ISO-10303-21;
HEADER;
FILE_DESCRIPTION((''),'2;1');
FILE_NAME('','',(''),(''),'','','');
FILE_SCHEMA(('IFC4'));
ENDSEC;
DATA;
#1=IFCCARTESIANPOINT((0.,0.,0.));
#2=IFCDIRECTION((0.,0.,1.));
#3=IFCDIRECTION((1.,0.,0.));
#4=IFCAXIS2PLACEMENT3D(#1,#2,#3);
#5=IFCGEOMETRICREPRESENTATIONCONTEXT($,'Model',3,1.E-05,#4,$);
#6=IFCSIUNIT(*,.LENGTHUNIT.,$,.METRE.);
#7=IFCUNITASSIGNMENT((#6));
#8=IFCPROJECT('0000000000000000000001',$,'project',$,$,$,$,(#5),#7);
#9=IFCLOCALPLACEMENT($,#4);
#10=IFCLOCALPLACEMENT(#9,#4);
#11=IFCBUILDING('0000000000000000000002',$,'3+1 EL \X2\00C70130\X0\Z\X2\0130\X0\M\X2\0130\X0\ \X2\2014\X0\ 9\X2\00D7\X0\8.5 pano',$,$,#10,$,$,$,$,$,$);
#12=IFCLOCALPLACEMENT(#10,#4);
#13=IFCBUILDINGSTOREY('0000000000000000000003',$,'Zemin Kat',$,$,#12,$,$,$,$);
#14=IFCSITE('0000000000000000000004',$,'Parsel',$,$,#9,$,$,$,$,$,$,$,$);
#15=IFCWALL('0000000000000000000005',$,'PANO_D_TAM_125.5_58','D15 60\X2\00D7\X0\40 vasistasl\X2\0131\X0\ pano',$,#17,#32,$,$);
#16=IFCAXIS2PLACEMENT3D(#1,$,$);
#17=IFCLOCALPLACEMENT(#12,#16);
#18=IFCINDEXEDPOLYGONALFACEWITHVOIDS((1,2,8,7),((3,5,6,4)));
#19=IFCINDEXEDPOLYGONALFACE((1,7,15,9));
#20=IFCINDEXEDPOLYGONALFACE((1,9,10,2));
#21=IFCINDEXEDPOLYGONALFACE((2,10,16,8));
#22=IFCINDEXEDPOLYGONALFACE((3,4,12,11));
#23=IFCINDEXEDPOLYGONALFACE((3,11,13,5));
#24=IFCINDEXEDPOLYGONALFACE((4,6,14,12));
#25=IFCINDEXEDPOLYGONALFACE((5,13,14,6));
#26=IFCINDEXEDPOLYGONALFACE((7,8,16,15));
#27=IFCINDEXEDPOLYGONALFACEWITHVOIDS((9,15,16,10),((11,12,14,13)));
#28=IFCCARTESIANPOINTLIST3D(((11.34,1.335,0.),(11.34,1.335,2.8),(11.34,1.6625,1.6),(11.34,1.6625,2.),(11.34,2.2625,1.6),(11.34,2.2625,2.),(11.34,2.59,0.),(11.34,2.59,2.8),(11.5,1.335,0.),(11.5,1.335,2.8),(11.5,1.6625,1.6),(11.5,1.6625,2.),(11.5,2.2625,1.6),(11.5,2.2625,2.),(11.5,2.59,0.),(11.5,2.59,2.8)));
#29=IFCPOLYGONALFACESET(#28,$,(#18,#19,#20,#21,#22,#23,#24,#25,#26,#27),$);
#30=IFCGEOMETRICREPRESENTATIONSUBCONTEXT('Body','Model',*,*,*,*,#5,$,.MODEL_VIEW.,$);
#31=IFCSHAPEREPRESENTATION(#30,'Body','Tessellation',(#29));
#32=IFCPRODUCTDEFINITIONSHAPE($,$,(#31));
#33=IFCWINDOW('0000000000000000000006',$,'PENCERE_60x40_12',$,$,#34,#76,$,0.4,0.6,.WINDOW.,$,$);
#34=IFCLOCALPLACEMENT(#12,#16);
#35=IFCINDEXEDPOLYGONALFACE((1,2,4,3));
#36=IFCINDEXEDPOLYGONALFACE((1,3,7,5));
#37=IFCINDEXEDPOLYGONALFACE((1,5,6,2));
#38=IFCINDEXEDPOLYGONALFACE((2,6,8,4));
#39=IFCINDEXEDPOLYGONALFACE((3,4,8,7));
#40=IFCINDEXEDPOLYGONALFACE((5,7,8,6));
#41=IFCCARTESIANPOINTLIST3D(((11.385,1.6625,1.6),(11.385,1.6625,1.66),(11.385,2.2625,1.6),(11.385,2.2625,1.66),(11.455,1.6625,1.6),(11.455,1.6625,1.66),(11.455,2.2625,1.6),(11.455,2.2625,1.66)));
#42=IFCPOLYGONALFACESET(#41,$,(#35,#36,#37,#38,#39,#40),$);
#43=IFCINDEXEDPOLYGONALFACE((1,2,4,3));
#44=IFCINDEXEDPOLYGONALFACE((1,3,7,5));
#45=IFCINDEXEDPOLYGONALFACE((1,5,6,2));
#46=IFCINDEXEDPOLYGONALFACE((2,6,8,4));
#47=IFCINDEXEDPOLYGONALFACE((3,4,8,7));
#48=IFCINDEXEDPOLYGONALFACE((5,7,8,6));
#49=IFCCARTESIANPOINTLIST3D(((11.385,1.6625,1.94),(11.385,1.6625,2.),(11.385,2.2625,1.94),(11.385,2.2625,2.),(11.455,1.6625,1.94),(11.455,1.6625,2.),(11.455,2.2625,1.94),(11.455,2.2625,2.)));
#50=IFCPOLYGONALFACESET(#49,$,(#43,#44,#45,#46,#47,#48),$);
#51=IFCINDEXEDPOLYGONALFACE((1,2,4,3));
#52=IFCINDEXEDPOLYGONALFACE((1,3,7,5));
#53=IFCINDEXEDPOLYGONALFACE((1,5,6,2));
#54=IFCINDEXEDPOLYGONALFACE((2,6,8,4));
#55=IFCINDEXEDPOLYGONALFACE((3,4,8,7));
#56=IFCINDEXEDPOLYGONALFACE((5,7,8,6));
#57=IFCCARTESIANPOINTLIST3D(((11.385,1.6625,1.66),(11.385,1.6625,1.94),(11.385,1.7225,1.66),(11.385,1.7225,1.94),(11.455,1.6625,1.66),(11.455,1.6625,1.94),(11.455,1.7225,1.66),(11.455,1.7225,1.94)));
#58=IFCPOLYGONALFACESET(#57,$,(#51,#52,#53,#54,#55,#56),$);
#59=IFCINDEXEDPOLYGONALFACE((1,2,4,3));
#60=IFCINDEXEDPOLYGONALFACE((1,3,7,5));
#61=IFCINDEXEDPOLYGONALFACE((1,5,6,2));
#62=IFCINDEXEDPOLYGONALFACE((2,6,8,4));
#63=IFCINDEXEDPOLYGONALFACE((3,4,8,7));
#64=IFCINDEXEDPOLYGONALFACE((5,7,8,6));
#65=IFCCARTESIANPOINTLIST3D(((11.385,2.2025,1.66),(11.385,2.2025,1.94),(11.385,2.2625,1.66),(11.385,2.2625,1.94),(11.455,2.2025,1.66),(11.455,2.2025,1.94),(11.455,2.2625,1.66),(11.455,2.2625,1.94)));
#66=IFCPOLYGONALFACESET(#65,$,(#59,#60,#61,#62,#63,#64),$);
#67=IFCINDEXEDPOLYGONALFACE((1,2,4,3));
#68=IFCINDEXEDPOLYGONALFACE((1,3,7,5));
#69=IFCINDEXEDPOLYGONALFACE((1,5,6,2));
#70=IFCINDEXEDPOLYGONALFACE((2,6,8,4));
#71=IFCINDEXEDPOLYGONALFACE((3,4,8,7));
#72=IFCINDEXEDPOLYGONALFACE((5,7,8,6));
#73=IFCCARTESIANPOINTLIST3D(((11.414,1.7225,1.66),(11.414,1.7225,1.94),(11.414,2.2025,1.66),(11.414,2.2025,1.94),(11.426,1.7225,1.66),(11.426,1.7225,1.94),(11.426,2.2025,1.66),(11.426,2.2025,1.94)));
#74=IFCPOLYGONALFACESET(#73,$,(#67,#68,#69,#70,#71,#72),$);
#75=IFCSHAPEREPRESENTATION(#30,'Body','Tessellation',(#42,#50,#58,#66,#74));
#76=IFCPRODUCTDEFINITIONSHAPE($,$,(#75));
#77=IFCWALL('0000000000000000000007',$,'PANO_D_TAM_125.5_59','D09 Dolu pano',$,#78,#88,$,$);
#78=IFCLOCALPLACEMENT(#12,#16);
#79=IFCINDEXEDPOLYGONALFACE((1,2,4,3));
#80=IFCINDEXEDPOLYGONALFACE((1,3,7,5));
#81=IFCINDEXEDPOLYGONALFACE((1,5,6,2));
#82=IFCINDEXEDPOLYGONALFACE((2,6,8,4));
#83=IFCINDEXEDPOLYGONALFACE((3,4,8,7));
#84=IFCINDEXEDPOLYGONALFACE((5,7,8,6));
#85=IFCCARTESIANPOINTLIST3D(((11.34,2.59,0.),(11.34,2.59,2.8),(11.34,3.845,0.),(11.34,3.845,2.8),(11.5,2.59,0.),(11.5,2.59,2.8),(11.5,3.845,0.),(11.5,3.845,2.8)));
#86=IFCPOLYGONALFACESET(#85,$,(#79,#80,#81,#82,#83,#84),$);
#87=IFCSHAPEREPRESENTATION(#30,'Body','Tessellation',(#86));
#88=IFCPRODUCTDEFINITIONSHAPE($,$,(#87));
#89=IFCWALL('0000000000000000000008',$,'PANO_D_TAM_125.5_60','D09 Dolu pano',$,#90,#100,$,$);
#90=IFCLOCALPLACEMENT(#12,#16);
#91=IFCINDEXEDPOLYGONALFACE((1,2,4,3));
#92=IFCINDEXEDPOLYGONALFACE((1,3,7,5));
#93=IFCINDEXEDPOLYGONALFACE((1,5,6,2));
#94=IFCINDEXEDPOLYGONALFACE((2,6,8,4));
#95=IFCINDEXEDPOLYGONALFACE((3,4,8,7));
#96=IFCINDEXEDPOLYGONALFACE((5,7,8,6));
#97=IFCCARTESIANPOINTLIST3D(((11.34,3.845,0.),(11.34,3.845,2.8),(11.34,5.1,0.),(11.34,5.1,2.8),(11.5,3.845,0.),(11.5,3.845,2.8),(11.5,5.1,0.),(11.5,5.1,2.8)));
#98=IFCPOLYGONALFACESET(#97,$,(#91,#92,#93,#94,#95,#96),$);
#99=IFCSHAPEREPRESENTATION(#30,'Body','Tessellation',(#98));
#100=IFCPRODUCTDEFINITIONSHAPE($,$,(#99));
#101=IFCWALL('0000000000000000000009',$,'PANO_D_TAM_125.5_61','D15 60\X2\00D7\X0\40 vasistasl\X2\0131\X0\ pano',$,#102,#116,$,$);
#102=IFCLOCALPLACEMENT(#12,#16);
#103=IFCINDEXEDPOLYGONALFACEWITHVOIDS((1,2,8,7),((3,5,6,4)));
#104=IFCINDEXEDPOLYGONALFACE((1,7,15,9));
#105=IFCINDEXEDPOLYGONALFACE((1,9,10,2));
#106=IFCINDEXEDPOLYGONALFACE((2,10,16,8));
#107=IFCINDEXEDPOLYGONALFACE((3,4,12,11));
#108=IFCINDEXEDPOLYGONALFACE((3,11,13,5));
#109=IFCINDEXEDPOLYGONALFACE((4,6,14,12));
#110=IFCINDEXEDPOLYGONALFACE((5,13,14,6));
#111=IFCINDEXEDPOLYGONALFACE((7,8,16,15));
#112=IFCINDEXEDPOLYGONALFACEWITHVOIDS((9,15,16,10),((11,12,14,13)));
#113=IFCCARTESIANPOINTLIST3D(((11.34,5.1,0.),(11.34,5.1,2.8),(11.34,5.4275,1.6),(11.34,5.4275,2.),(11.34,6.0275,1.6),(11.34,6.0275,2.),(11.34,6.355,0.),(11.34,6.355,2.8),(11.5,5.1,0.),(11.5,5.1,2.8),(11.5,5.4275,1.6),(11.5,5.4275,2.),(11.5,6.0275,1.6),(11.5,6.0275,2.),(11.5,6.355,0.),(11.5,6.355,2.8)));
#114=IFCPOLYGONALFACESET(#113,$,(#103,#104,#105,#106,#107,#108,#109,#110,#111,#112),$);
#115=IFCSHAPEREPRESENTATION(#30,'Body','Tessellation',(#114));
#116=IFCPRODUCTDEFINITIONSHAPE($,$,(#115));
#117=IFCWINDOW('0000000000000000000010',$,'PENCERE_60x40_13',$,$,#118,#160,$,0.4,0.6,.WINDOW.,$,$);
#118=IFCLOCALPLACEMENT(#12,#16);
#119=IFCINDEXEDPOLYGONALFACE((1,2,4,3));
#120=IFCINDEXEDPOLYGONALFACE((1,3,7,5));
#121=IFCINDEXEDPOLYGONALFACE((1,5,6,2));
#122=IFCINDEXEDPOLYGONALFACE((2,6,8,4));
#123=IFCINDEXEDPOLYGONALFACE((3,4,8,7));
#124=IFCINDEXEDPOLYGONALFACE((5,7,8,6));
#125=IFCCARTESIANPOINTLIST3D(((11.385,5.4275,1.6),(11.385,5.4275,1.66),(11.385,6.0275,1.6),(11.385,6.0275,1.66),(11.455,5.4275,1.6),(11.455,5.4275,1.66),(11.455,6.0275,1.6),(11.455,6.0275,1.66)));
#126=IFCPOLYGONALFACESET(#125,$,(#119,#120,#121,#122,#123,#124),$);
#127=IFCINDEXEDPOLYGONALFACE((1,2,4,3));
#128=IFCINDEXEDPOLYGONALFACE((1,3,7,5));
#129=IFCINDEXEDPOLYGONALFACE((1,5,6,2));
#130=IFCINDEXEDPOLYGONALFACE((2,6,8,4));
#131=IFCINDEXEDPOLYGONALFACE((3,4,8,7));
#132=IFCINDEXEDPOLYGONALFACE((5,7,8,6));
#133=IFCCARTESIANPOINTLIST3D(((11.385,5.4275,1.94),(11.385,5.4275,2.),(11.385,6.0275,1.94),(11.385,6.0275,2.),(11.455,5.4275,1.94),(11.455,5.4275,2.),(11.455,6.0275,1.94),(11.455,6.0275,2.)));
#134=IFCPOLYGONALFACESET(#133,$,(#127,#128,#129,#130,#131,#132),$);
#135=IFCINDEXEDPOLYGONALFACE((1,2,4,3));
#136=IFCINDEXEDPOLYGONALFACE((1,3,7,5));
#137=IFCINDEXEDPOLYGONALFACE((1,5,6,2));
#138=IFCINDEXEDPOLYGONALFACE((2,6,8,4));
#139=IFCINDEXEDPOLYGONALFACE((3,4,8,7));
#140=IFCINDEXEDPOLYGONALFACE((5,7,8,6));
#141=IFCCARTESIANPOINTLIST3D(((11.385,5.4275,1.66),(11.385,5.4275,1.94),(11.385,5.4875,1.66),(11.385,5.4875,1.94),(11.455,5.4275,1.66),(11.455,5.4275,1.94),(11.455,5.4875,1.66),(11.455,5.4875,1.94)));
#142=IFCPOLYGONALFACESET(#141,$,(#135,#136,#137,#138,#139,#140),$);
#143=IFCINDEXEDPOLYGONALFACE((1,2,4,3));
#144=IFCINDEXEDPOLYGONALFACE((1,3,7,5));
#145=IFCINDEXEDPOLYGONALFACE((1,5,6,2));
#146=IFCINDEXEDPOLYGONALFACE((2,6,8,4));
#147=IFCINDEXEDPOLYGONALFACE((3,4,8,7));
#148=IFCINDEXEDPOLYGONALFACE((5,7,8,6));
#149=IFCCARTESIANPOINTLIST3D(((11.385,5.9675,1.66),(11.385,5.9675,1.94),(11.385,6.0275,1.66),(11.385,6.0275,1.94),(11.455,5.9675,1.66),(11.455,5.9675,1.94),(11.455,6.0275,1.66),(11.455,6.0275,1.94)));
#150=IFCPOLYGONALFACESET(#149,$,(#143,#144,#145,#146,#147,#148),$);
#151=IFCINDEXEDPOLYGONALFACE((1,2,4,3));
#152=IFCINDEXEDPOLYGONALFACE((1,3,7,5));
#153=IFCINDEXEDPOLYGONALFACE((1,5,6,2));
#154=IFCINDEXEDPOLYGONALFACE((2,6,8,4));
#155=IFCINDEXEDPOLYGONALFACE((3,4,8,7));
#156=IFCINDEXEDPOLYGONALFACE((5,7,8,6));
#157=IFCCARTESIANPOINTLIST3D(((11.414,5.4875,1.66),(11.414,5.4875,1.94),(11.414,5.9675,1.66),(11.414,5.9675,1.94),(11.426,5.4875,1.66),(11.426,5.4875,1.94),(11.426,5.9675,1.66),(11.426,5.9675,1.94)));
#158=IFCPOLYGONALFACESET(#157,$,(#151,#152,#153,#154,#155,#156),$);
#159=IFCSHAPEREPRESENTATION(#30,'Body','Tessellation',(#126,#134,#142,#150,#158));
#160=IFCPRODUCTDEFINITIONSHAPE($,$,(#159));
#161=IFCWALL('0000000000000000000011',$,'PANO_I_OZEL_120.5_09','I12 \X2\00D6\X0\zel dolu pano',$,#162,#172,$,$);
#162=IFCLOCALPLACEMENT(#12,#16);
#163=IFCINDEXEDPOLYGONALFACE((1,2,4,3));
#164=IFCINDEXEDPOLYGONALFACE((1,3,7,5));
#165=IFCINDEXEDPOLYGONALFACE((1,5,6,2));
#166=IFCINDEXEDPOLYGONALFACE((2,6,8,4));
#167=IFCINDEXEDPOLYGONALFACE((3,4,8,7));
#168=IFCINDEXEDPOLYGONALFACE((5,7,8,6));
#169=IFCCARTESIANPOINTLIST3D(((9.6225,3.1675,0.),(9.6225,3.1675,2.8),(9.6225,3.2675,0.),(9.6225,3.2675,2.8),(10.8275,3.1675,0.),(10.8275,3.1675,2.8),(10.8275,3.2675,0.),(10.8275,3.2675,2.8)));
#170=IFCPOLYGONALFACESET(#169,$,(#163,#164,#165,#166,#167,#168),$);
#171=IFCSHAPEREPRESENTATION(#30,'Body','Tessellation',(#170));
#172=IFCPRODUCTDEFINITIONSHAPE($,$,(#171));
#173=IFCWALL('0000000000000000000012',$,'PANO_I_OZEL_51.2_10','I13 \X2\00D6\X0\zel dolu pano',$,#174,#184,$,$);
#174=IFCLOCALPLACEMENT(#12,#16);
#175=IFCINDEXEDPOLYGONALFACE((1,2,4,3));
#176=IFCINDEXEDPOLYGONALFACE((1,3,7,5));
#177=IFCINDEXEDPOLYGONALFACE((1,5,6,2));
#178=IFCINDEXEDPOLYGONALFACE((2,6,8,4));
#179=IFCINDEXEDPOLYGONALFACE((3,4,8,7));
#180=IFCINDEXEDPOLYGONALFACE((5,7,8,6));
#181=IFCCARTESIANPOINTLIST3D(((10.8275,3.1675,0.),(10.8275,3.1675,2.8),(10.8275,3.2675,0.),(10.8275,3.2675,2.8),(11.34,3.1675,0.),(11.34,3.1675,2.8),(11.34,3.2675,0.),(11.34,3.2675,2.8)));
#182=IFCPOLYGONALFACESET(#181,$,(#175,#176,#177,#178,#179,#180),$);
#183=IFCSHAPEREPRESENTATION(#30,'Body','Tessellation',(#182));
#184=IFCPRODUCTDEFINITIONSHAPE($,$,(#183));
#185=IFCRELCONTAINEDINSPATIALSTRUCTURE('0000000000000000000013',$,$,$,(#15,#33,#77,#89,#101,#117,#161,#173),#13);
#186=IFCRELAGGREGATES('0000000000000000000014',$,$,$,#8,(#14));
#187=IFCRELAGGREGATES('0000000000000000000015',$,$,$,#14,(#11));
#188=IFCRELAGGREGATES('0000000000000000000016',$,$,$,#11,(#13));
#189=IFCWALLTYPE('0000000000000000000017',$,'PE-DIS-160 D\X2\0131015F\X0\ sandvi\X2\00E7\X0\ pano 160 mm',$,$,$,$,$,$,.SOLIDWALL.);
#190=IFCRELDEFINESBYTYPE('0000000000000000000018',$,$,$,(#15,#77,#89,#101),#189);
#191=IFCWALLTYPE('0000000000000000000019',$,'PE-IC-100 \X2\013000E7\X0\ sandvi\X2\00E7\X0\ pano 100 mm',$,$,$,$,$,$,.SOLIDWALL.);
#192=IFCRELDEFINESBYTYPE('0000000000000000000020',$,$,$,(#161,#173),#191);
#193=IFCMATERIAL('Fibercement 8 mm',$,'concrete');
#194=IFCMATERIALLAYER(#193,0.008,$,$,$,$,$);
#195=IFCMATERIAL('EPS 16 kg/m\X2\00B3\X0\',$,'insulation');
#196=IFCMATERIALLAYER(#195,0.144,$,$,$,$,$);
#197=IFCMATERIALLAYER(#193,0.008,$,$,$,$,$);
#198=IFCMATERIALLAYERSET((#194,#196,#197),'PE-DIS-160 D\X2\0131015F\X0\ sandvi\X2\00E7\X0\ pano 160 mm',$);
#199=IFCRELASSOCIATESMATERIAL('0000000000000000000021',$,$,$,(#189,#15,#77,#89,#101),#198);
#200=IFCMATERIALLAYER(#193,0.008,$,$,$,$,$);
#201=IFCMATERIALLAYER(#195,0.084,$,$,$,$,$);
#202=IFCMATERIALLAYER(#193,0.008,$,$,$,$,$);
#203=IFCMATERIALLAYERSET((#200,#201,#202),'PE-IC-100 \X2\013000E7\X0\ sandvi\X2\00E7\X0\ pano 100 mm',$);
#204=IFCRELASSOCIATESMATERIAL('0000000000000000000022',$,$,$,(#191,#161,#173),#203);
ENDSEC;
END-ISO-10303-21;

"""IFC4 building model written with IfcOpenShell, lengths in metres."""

from ifc_helpers import new_model, si_unit, frame, origin_with_axes, place, context, subcontext, project, spatial, line, indexed_curve, outline, extrude, material, layer, layer_set, layer_usage, type_object, element, fill, save


model = new_model("IFC4")

# Units and contexts
model_context = context("Model", 3, precision=1e-05, world=origin_with_axes())
body_context = subcontext(model_context, "Body", "Model", "MODEL_VIEW")
ifc_project = project(units=[si_unit("LENGTHUNIT", "METRE")], contexts=[model_context])

# Site, building, storey
site_placement = place(None, origin_with_axes())
site = spatial("IfcSite", under=ifc_project, at=site_placement, Name="Parsel")
building_placement = place(site_placement, origin_with_axes())
building = spatial("IfcBuilding", under=site, at=building_placement, Name="3+1 EL ÇİZİMİ — 9×8.5 pano")
storey_placement = place(building_placement, origin_with_axes())
storey = spatial("IfcBuildingStorey", under=building, at=storey_placement, Name="Zemin Kat")

# Shared definitions
ifc_material_1 = material(Name="Fibercement 8 mm", Category="concrete")
ifc_layer_1 = layer(ifc_material_1, 0.008)
ifc_material_2 = material(Name="EPS 16 kg/m³", Category="insulation")
ifc_layer_2 = layer(ifc_material_2, 0.144)
ifc_layer_3 = layer(ifc_material_1, 0.008)
ifc_layer_set_1 = layer_set([ifc_layer_1, ifc_layer_2, ifc_layer_3], Name="PE-DIS-160 Dış sandviç pano 160 mm")
wall_type_1 = type_object("IfcWallType", Name="PE-DIS-160 Dış sandviç pano 160 mm", PredefinedType="SOLIDWALL", material=ifc_layer_set_1)

# Wall, opening, window
ifc_layer_usage_1 = layer_usage(ifc_layer_set_1, "AXIS2", "POSITIVE", 0.0)
wall_1_placement = place(storey_placement, frame((11.5, 1.335, 0.0), z_axis=(0.0, 0.0, 1.0), x_axis=(0.0, 1.0, 0.0)))
wall_1 = element("IfcWall", 1, at=wall_1_placement, inside=storey, type_object=wall_type_1, material=ifc_layer_usage_1, Name="PANO_D_TAM_125.5_58", Description="D15 60×40 vasistaslı pano", context=body_context, shape_type="SweptSolid", body=[
    extrude(outline(indexed_curve([(0.0, 0.0), (1.255, 0.0), (1.255, 0.16), (0.0, 0.16)], segments=[line(1, 2, 3, 4, 1)])), origin_with_axes(), (0.0, 0.0, 1.0), 2.8),
])
opening_1_placement = place(wall_1_placement, origin_with_axes())
opening_1 = element("IfcOpeningElement", 2, at=opening_1_placement, cuts=wall_1, PredefinedType="OPENING", context=body_context, shape_type="SweptSolid", body=[
    extrude(outline(indexed_curve([(0.0, 0.0), (0.6, 0.0), (0.6, 0.2), (0.0, 0.2)], segments=[line(1, 2, 3, 4, 1)])), frame((0.3275, -0.02, 1.6), z_axis=(0.0, 0.0, 1.0), x_axis=(1.0, 0.0, 0.0)), (0.0, 0.0, 1.0), 0.4),
])
window_1_placement = place(storey_placement, frame((11.5, 1.335, 0.0), z_axis=(0.0, 0.0, 1.0), x_axis=(0.0, 1.0, 0.0)))
window_1 = element("IfcWindow", 3, at=window_1_placement, inside=storey, Name="PENCERE_60x40_12", OverallHeight=0.4, OverallWidth=0.6, PredefinedType="WINDOW", context=body_context, shape_type="SweptSolid", body=[
    extrude(outline(indexed_curve([(0.0, 0.0), (0.6, 0.0), (0.6, 0.07), (0.0, 0.07)], segments=[line(1, 2, 3, 4, 1)])), frame((0.3275, 0.045, 1.6), z_axis=(0.0, 0.0, 1.0), x_axis=(1.0, 0.0, 0.0)), (0.0, 0.0, 1.0), 0.06),
    extrude(outline(indexed_curve([(0.0, 0.0), (0.6, 0.0), (0.6, 0.07), (0.0, 0.07)], segments=[line(1, 2, 3, 4, 1)])), frame((0.3275, 0.045, 1.94), z_axis=(0.0, 0.0, 1.0), x_axis=(1.0, 0.0, 0.0)), (0.0, 0.0, 1.0), 0.06),
    extrude(outline(indexed_curve([(0.0, 0.0), (0.06, 0.0), (0.06, 0.07), (0.0, 0.07)], segments=[line(1, 2, 3, 4, 1)])), frame((0.3275, 0.045, 1.66), z_axis=(0.0, 0.0, 1.0), x_axis=(1.0, 0.0, 0.0)), (0.0, 0.0, 1.0), 0.28),
    extrude(outline(indexed_curve([(0.0, 0.0), (0.06, 0.0), (0.06, 0.07), (0.0, 0.07)], segments=[line(1, 2, 3, 4, 1)])), frame((0.8675, 0.045, 1.66), z_axis=(0.0, 0.0, 1.0), x_axis=(1.0, 0.0, 0.0)), (0.0, 0.0, 1.0), 0.28),
    extrude(outline(indexed_curve([(0.0, 0.0), (0.48, 0.0), (0.48, 0.012), (0.0, 0.012)], segments=[line(1, 2, 3, 4, 1)])), frame((0.3875, 0.074, 1.66), z_axis=(0.0, 0.0, 1.0), x_axis=(1.0, 0.0, 0.0)), (0.0, 0.0, 1.0), 0.28),
])
fill(opening_1, window_1)

# Walls
ifc_layer_usage_2 = layer_usage(ifc_layer_set_1, "AXIS2", "POSITIVE", 0.0)
wall_2_placement = place(storey_placement, frame((11.5, 2.59, 0.0), z_axis=(0.0, 0.0, 1.0), x_axis=(0.0, 1.0, 0.0)))
element("IfcWall", 4, at=wall_2_placement, inside=storey, type_object=wall_type_1, material=ifc_layer_usage_2, Name="PANO_D_TAM_125.5_59", Description="D09 Dolu pano", context=body_context, shape_type="SweptSolid", body=[
    extrude(outline(indexed_curve([(0.0, 0.0), (1.255, 0.0), (1.255, 0.16), (0.0, 0.16)], segments=[line(1, 2, 3, 4, 1)])), origin_with_axes(), (0.0, 0.0, 1.0), 2.8),
])
ifc_layer_usage_3 = layer_usage(ifc_layer_set_1, "AXIS2", "POSITIVE", 0.0)
wall_3_placement = place(storey_placement, frame((11.5, 3.845, 0.0), z_axis=(0.0, 0.0, 1.0), x_axis=(0.0, 1.0, 0.0)))
element("IfcWall", 5, at=wall_3_placement, inside=storey, type_object=wall_type_1, material=ifc_layer_usage_3, Name="PANO_D_TAM_125.5_60", Description="D09 Dolu pano", context=body_context, shape_type="SweptSolid", body=[
    extrude(outline(indexed_curve([(0.0, 0.0), (1.255, 0.0), (1.255, 0.16), (0.0, 0.16)], segments=[line(1, 2, 3, 4, 1)])), origin_with_axes(), (0.0, 0.0, 1.0), 2.8),
])

# Wall, opening, window
ifc_layer_usage_4 = layer_usage(ifc_layer_set_1, "AXIS2", "POSITIVE", 0.0)
wall_4_placement = place(storey_placement, frame((11.5, 5.1, 0.0), z_axis=(0.0, 0.0, 1.0), x_axis=(0.0, 1.0, 0.0)))
wall_4 = element("IfcWall", 6, at=wall_4_placement, inside=storey, type_object=wall_type_1, material=ifc_layer_usage_4, Name="PANO_D_TAM_125.5_61", Description="D15 60×40 vasistaslı pano", context=body_context, shape_type="SweptSolid", body=[
    extrude(outline(indexed_curve([(0.0, 0.0), (1.255, 0.0), (1.255, 0.16), (0.0, 0.16)], segments=[line(1, 2, 3, 4, 1)])), origin_with_axes(), (0.0, 0.0, 1.0), 2.8),
])
opening_2_placement = place(wall_4_placement, origin_with_axes())
opening_2 = element("IfcOpeningElement", 7, at=opening_2_placement, cuts=wall_4, PredefinedType="OPENING", context=body_context, shape_type="SweptSolid", body=[
    extrude(outline(indexed_curve([(0.0, 0.0), (0.6, 0.0), (0.6, 0.2), (0.0, 0.2)], segments=[line(1, 2, 3, 4, 1)])), frame((0.3275, -0.02, 1.6), z_axis=(0.0, 0.0, 1.0), x_axis=(1.0, 0.0, 0.0)), (0.0, 0.0, 1.0), 0.4),
])
window_2_placement = place(storey_placement, frame((11.5, 5.1, 0.0), z_axis=(0.0, 0.0, 1.0), x_axis=(0.0, 1.0, 0.0)))
window_2 = element("IfcWindow", 8, at=window_2_placement, inside=storey, Name="PENCERE_60x40_13", OverallHeight=0.4, OverallWidth=0.6, PredefinedType="WINDOW", context=body_context, shape_type="SweptSolid", body=[
    extrude(outline(indexed_curve([(0.0, 0.0), (0.6, 0.0), (0.6, 0.07), (0.0, 0.07)], segments=[line(1, 2, 3, 4, 1)])), frame((0.3275, 0.045, 1.6), z_axis=(0.0, 0.0, 1.0), x_axis=(1.0, 0.0, 0.0)), (0.0, 0.0, 1.0), 0.06),
    extrude(outline(indexed_curve([(0.0, 0.0), (0.6, 0.0), (0.6, 0.07), (0.0, 0.07)], segments=[line(1, 2, 3, 4, 1)])), frame((0.3275, 0.045, 1.94), z_axis=(0.0, 0.0, 1.0), x_axis=(1.0, 0.0, 0.0)), (0.0, 0.0, 1.0), 0.06),
    extrude(outline(indexed_curve([(0.0, 0.0), (0.06, 0.0), (0.06, 0.07), (0.0, 0.07)], segments=[line(1, 2, 3, 4, 1)])), frame((0.3275, 0.045, 1.66), z_axis=(0.0, 0.0, 1.0), x_axis=(1.0, 0.0, 0.0)), (0.0, 0.0, 1.0), 0.28),
    extrude(outline(indexed_curve([(0.0, 0.0), (0.06, 0.0), (0.06, 0.07), (0.0, 0.07)], segments=[line(1, 2, 3, 4, 1)])), frame((0.8675, 0.045, 1.66), z_axis=(0.0, 0.0, 1.0), x_axis=(1.0, 0.0, 0.0)), (0.0, 0.0, 1.0), 0.28),
    extrude(outline(indexed_curve([(0.0, 0.0), (0.48, 0.0), (0.48, 0.012), (0.0, 0.012)], segments=[line(1, 2, 3, 4, 1)])), frame((0.3875, 0.074, 1.66), z_axis=(0.0, 0.0, 1.0), x_axis=(1.0, 0.0, 0.0)), (0.0, 0.0, 1.0), 0.28),
])
fill(opening_2, window_2)

# Walls
ifc_layer_4 = layer(ifc_material_1, 0.008)
ifc_layer_5 = layer(ifc_material_2, 0.084)
ifc_layer_6 = layer(ifc_material_1, 0.008)
ifc_layer_set_2 = layer_set([ifc_layer_4, ifc_layer_5, ifc_layer_6], Name="PE-IC-100 İç sandviç pano 100 mm")
ifc_layer_usage_5 = layer_usage(ifc_layer_set_2, "AXIS2", "POSITIVE", 0.0)
wall_type_2 = type_object("IfcWallType", Name="PE-IC-100 İç sandviç pano 100 mm", PredefinedType="SOLIDWALL", material=ifc_layer_set_2)
wall_5_placement = place(storey_placement, frame((9.6225, 3.1675, 0.0), z_axis=(0.0, 0.0, 1.0), x_axis=(1.0, 0.0, 0.0)))
element("IfcWall", 9, at=wall_5_placement, inside=storey, type_object=wall_type_2, material=ifc_layer_usage_5, Name="PANO_I_OZEL_120.5_09", Description="I12 Özel dolu pano", context=body_context, shape_type="SweptSolid", body=[
    extrude(outline(indexed_curve([(0.0, 0.0), (1.205, 0.0), (1.205, 0.1), (0.0, 0.1)], segments=[line(1, 2, 3, 4, 1)])), origin_with_axes(), (0.0, 0.0, 1.0), 2.8),
])
ifc_layer_usage_6 = layer_usage(ifc_layer_set_2, "AXIS2", "POSITIVE", 0.0)
wall_6_placement = place(storey_placement, frame((10.8275, 3.1675, 0.0), z_axis=(0.0, 0.0, 1.0), x_axis=(1.0, 0.0, 0.0)))
element("IfcWall", 10, at=wall_6_placement, inside=storey, type_object=wall_type_2, material=ifc_layer_usage_6, Name="PANO_I_OZEL_51.2_10", Description="I13 Özel dolu pano", context=body_context, shape_type="SweptSolid", body=[
    extrude(outline(indexed_curve([(0.0, 0.0), (0.5125, 0.0), (0.5125, 0.1), (0.0, 0.1)], segments=[line(1, 2, 3, 4, 1)])), origin_with_axes(), (0.0, 0.0, 1.0), 2.8),
])

save(model, "model.ifc")
